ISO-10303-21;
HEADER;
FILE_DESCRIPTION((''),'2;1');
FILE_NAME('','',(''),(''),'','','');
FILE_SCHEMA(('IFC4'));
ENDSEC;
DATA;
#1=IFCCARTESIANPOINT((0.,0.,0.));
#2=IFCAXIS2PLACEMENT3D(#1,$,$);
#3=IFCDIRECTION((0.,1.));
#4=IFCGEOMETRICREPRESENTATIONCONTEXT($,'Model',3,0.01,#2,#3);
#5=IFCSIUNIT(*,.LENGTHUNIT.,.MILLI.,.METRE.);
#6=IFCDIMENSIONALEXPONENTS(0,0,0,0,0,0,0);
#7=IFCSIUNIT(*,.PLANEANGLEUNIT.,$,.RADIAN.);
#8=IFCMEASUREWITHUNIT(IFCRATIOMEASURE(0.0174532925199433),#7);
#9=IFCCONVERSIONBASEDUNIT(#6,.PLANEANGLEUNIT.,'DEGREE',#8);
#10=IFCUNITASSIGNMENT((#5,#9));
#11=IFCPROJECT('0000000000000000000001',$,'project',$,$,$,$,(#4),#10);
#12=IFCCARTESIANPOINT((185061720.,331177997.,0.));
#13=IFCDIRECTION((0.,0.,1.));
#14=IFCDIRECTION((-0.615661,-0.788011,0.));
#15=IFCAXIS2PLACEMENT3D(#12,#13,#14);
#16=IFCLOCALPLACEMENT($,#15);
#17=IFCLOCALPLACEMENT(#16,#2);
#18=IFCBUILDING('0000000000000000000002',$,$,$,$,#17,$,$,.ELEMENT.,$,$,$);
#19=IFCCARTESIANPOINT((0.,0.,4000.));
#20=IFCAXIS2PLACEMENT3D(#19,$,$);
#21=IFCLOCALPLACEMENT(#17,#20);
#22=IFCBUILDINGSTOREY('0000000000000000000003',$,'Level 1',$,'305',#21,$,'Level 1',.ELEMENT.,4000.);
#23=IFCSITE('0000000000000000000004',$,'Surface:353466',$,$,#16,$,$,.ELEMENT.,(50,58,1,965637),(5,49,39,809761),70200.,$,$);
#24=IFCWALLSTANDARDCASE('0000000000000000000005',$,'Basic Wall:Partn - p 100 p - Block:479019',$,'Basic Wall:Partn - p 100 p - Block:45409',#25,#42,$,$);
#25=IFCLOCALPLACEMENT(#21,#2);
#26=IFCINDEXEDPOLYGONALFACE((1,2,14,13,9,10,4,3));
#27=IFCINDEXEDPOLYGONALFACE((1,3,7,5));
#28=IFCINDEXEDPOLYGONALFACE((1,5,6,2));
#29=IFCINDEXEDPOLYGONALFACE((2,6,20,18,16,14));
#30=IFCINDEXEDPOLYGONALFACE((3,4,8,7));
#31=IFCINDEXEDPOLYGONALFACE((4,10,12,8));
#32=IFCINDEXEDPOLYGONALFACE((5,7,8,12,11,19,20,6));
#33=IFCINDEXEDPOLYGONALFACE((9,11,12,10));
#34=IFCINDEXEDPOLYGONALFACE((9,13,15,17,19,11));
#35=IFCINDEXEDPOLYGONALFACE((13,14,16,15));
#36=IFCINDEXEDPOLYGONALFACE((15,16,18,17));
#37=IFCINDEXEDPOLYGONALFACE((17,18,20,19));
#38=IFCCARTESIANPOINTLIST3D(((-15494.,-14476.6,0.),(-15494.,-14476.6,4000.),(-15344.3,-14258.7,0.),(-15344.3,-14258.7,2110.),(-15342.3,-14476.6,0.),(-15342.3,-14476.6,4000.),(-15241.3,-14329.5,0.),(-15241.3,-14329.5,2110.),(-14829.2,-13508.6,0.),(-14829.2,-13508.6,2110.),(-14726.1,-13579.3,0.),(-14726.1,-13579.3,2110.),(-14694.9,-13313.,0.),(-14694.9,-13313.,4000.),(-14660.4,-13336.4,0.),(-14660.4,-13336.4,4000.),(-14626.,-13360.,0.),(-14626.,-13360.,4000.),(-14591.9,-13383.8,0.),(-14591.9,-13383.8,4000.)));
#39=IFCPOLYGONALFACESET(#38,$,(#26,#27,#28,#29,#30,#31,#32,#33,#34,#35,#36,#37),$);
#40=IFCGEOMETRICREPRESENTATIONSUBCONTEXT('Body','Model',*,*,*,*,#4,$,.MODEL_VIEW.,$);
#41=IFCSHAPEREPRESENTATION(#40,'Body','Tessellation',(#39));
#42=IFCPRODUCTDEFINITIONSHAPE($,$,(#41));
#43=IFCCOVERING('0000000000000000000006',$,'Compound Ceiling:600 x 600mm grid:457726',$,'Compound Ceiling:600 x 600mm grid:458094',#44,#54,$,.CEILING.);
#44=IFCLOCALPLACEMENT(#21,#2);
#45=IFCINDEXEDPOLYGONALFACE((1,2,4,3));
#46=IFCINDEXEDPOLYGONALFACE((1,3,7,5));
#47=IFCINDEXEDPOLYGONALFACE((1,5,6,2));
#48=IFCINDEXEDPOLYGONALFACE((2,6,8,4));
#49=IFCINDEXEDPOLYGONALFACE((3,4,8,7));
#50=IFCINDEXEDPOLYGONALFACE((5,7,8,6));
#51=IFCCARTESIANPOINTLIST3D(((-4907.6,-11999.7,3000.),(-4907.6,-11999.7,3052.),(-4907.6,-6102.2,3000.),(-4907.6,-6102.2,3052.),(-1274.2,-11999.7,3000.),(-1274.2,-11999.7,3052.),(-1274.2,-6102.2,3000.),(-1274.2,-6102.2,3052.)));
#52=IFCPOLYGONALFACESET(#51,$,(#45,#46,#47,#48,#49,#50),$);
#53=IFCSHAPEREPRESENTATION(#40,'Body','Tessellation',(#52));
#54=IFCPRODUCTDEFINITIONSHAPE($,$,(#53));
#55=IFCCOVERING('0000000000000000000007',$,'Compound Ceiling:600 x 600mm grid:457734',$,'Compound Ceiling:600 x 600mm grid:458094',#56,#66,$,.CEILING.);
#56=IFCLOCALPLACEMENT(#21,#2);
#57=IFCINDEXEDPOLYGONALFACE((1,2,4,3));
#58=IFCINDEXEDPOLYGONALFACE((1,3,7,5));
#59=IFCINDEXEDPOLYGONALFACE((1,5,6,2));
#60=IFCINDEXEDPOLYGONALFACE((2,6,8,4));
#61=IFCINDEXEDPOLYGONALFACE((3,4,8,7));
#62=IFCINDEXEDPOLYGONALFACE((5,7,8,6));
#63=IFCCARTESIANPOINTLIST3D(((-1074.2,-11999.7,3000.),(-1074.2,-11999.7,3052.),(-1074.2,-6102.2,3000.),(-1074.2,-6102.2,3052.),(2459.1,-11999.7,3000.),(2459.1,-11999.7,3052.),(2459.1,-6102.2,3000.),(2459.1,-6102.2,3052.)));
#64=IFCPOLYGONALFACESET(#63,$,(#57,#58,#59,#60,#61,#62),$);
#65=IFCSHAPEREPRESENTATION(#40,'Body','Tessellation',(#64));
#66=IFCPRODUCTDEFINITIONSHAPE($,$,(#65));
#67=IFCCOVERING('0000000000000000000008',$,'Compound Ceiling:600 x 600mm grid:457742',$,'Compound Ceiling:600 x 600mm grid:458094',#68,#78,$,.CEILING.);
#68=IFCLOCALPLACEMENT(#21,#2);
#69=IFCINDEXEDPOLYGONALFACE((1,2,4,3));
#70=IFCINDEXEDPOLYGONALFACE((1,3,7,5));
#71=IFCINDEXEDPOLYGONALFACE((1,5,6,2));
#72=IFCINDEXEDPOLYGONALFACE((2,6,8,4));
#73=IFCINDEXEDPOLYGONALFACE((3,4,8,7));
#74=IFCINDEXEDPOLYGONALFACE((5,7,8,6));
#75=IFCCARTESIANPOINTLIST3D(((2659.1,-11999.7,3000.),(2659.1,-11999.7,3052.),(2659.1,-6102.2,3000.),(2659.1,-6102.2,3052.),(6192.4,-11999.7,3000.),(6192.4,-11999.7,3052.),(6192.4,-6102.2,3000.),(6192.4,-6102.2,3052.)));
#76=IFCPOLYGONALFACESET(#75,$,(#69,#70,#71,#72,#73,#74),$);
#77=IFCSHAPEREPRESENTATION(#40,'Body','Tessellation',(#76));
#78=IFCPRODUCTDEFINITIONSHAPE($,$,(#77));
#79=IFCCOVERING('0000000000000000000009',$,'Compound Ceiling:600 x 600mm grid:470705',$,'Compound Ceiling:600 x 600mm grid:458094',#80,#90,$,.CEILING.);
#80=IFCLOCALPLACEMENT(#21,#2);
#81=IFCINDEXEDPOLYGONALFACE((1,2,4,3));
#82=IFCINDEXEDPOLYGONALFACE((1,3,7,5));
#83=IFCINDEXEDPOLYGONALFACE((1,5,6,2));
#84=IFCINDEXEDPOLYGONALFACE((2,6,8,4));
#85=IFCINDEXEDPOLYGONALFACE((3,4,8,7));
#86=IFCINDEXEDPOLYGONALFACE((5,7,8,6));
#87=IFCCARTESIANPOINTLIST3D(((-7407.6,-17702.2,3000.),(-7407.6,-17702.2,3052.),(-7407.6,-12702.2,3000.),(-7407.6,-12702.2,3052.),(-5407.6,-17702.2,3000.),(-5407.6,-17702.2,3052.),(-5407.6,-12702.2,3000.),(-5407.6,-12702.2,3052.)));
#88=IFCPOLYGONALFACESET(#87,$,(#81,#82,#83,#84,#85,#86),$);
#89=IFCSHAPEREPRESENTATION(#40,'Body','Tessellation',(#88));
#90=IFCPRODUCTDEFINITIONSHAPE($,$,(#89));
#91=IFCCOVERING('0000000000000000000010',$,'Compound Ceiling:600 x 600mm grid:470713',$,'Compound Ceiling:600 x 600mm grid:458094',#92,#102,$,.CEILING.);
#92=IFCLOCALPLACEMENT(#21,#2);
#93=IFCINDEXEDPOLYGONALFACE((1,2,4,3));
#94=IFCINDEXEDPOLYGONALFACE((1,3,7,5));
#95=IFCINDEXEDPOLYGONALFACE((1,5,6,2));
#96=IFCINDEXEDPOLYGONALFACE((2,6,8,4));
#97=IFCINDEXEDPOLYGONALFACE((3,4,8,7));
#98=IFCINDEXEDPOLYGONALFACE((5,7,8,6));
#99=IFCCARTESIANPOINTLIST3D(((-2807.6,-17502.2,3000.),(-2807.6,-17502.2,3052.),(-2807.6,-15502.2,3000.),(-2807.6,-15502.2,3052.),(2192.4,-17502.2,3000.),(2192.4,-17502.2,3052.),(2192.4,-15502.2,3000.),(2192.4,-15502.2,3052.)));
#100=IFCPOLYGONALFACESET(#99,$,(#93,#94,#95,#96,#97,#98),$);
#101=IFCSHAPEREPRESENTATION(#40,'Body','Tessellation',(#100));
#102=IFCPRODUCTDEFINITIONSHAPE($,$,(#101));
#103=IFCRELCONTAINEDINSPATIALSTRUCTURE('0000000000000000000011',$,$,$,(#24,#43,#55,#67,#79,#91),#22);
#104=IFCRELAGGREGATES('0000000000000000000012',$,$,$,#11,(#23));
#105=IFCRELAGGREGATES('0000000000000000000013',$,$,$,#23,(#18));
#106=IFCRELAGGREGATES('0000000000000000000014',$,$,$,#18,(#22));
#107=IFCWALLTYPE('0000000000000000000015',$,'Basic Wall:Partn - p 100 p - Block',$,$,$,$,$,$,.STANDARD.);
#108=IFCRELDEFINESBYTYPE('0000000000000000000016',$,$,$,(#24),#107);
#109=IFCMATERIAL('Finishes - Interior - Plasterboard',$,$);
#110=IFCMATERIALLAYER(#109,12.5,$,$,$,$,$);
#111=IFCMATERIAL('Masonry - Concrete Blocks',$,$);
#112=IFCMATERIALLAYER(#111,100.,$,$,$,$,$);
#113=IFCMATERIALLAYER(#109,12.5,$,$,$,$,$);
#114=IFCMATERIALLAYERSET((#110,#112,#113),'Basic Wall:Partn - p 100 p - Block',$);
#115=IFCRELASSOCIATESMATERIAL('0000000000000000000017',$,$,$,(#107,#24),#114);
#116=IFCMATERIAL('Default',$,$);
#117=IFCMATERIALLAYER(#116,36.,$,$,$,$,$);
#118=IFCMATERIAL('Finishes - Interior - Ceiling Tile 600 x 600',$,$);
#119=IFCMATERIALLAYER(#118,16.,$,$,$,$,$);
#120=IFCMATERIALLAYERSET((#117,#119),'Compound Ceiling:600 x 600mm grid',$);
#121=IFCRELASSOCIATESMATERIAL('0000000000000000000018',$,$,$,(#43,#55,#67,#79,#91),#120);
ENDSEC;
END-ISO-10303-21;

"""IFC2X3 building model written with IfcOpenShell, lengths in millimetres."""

from ifc_helpers import new_model, entity, si_unit, converted_unit, direction, frame, frame_2d, origin, origin_2d_with_axis, place, context, subcontext, project, spatial, polyline, circle_curve, parameter, trimmed, segment, composite_curve, rectangle, outline, extrude, clip, halfspace, material, layer, layer_set, layer_usage, type_object, element, save


model = new_model("IFC2X3")

# Units and contexts
model_context = context("Model", 3, precision=0.01, world=origin(), true_north=direction((0.0, 1.0)))
body_context = subcontext(model_context, "Body", "Model", "MODEL_VIEW")
ifc_project = project(units=[si_unit("LENGTHUNIT", "METRE", prefix="MILLI"), converted_unit("PLANEANGLEUNIT", "DEGREE", entity("IfcRatioMeasure", 0.0174532925199433), si_unit("PLANEANGLEUNIT", "RADIAN"), dimensions=[0, 0, 0, 0, 0, 0, 0])], contexts=[model_context])

# Site, building, storey
site_placement = place(None, frame((185061720.0, 331177997.0, 0.0), z_axis=(0.0, 0.0, 1.0), x_axis=(-0.615661, -0.788011, 0.0)))
site = spatial("IfcSite", under=ifc_project, at=site_placement, Name="Surface:353466", CompositionType="ELEMENT", RefLatitude=(50, 58, 1, 965637), RefLongitude=(5, 49, 39, 809761), RefElevation=70200.0)
building_placement = place(site_placement, origin())
building = spatial("IfcBuilding", under=site, at=building_placement, CompositionType="ELEMENT")
storey_placement = place(building_placement, frame((0.0, 0.0, 4000.0)))
storey = spatial("IfcBuildingStorey", under=building, at=storey_placement, Name="Level 1", ObjectType="305", LongName="Level 1", CompositionType="ELEMENT", Elevation=4000.0)

# Shared definitions
ifc_material_1 = material(Name="Masonry - Concrete Blocks")
ifc_material_2 = material(Name="Finishes - Interior - Plasterboard")

# Shared definitions
ifc_layer_1 = layer(ifc_material_2, 12.5)
ifc_layer_2 = layer(ifc_material_1, 100.0)
ifc_layer_3 = layer(ifc_material_2, 12.5)
ifc_layer_set_1 = layer_set([ifc_layer_1, ifc_layer_2, ifc_layer_3], Name="Basic Wall:Partn - p 100 p - Block")
wall_type_1 = type_object("IfcWallType", Name="Basic Wall:Partn - p 100 p - Block", PredefinedType="STANDARD", material=ifc_layer_set_1)

# Wall, openings
ifc_layer_usage_1 = layer_usage(ifc_layer_set_1, "AXIS2", "NEGATIVE", 62.5)
wall_1_placement = place(storey_placement, frame((-14643.4, -13348.4, 0.0), z_axis=(0.0, 0.0, 1.0), x_axis=(-0.566097, -0.824338, 0.0)))
wall_1 = element("IfcWallStandardCase", 1, at=wall_1_placement, inside=storey, type_object=wall_type_1, material=ifc_layer_usage_1, Name="Basic Wall:Partn - p 100 p - Block:479019", ObjectType="Basic Wall:Partn - p 100 p - Block:45409", context=body_context, shape_type="Clipping", body=[
    clip(extrude(outline(composite_curve([segment(polyline([(0.0, -62.5), (1411.6, -62.5)]), True, "CONTINUOUS"), segment(polyline([(1411.6, -62.5), (1325.7, 62.5)]), True, "CONTINUOUS"), segment(polyline([(1325.7, 62.5), (0.0, 62.5)]), True, "CONTINUOUS"), segment(trimmed(circle_curve(frame_2d((6472.7, 0.0), x_axis=(-0.983187, 0.182604)), 6473.0), [parameter(9.968258)], [parameter(11.074705)], True, "PARAMETER"), True, "CONTINUOUS")], self_intersect=False)), origin(), (0.0, 0.0, 1.0), 4000.0), halfspace(origin(), True)),
])
opening_1_placement = place(wall_1_placement, frame((2569.6, -484.7, 0.0)))
element("IfcOpeningElement", 2, at=opening_1_placement, cuts=wall_1, ObjectType="Opening", context=body_context, shape_type="SweptSolid", body=[
    extrude(rectangle(XDim=2110.0, YDim=910.0, at=frame_2d((0.0, 0.0), x_axis=(1.0, 0.0))), frame((-1877.4, -976.8, 1055.0), z_axis=(0.0, 1.0, 0.0), x_axis=(0.0, 0.0, 1.0)), (0.0, 0.0, 1.0), 3048.0),
])
opening_2_placement = place(wall_1_placement, frame((1147.2, 62.5, 0.0)))
element("IfcOpeningElement", 3, at=opening_2_placement, cuts=wall_1, ObjectType="Opening", context=body_context, shape_type="SweptSolid", body=[
    extrude(rectangle(XDim=2110.0, YDim=910.0, at=frame_2d((1055.0, 455.0), x_axis=(1.0, 0.0))), frame((0.0, 0.0, 0.0), z_axis=(0.0, -1.0, 0.0), x_axis=(0.0, 0.0, 1.0)), (0.0, 0.0, 1.0), 125.0),
])

# Coverings
ifc_material_3 = material(Name="Default")
ifc_layer_4 = layer(ifc_material_3, 36.0)
ifc_material_4 = material(Name="Finishes - Interior - Ceiling Tile 600 x 600")
ifc_layer_5 = layer(ifc_material_4, 16.0)
ifc_layer_set_2 = layer_set([ifc_layer_4, ifc_layer_5], Name="Compound Ceiling:600 x 600mm grid")
ifc_layer_usage_2 = layer_usage(ifc_layer_set_2, "AXIS3", "POSITIVE", 0.0)
covering_1_placement = place(storey_placement, frame((-4907.6, -11999.7, 3000.0)))
element("IfcCovering", 4, at=covering_1_placement, inside=storey, material=ifc_layer_usage_2, Name="Compound Ceiling:600 x 600mm grid:457726", ObjectType="Compound Ceiling:600 x 600mm grid:458094", PredefinedType="CEILING", context=body_context, shape_type="SweptSolid", body=[
    extrude(rectangle(XDim=5897.5, YDim=3633.3, at=frame_2d((0.0, 0.0), x_axis=(1.0, 0.0))), frame((1816.7, 2948.8, 0.0), z_axis=(0.0, 0.0, 1.0), x_axis=(0.0, 1.0, 0.0)), (0.0, 0.0, 1.0), 52.0),
])
ifc_layer_usage_3 = layer_usage(ifc_layer_set_2, "AXIS3", "POSITIVE", 0.0)
covering_2_placement = place(storey_placement, frame((-1074.2, -11999.7, 3000.0)))
element("IfcCovering", 5, at=covering_2_placement, inside=storey, material=ifc_layer_usage_3, Name="Compound Ceiling:600 x 600mm grid:457734", ObjectType="Compound Ceiling:600 x 600mm grid:458094", PredefinedType="CEILING", context=body_context, shape_type="SweptSolid", body=[
    extrude(rectangle(XDim=3533.3, YDim=5897.5, at=frame_2d((0.0, 0.0), x_axis=(1.0, 0.0))), frame((1766.7, 2948.8, 0.0)), (0.0, 0.0, 1.0), 52.0),
])
ifc_layer_usage_4 = layer_usage(ifc_layer_set_2, "AXIS3", "POSITIVE", 0.0)
covering_3_placement = place(storey_placement, frame((2659.1, -11999.7, 3000.0)))
element("IfcCovering", 6, at=covering_3_placement, inside=storey, material=ifc_layer_usage_4, Name="Compound Ceiling:600 x 600mm grid:457742", ObjectType="Compound Ceiling:600 x 600mm grid:458094", PredefinedType="CEILING", context=body_context, shape_type="SweptSolid", body=[
    extrude(rectangle(XDim=3533.3, YDim=5897.5, at=frame_2d((0.0, 0.0), x_axis=(1.0, 0.0))), frame((1766.7, 2948.8, 0.0)), (0.0, 0.0, 1.0), 52.0),
])
ifc_layer_usage_5 = layer_usage(ifc_layer_set_2, "AXIS3", "POSITIVE", 0.0)
covering_4_placement = place(storey_placement, frame((-7407.6, -17702.2, 3000.0)))
element("IfcCovering", 7, at=covering_4_placement, inside=storey, material=ifc_layer_usage_5, Name="Compound Ceiling:600 x 600mm grid:470705", ObjectType="Compound Ceiling:600 x 600mm grid:458094", PredefinedType="CEILING", context=body_context, shape_type="SweptSolid", body=[
    extrude(rectangle(XDim=5000.0, YDim=2000.0, at=frame_2d((0.0, 0.0), x_axis=(1.0, 0.0))), frame((1000.0, 2500.0, 0.0), z_axis=(0.0, 0.0, 1.0), x_axis=(0.0, -1.0, 0.0)), (0.0, 0.0, 1.0), 52.0),
])
ifc_layer_usage_6 = layer_usage(ifc_layer_set_2, "AXIS3", "POSITIVE", 0.0)
covering_5_placement = place(storey_placement, frame((-2807.6, -17502.2, 3000.0)))
element("IfcCovering", 8, at=covering_5_placement, inside=storey, material=ifc_layer_usage_6, Name="Compound Ceiling:600 x 600mm grid:470713", ObjectType="Compound Ceiling:600 x 600mm grid:458094", PredefinedType="CEILING", context=body_context, shape_type="SweptSolid", body=[
    extrude(rectangle(XDim=2000.0, YDim=5000.0, at=origin_2d_with_axis()), frame((2500.0, 1000.0, 0.0), z_axis=(0.0, 0.0, 1.0), x_axis=(0.0, -1.0, 0.0)), (0.0, 0.0, 1.0), 52.0),
])

save(model, "model.ifc")
